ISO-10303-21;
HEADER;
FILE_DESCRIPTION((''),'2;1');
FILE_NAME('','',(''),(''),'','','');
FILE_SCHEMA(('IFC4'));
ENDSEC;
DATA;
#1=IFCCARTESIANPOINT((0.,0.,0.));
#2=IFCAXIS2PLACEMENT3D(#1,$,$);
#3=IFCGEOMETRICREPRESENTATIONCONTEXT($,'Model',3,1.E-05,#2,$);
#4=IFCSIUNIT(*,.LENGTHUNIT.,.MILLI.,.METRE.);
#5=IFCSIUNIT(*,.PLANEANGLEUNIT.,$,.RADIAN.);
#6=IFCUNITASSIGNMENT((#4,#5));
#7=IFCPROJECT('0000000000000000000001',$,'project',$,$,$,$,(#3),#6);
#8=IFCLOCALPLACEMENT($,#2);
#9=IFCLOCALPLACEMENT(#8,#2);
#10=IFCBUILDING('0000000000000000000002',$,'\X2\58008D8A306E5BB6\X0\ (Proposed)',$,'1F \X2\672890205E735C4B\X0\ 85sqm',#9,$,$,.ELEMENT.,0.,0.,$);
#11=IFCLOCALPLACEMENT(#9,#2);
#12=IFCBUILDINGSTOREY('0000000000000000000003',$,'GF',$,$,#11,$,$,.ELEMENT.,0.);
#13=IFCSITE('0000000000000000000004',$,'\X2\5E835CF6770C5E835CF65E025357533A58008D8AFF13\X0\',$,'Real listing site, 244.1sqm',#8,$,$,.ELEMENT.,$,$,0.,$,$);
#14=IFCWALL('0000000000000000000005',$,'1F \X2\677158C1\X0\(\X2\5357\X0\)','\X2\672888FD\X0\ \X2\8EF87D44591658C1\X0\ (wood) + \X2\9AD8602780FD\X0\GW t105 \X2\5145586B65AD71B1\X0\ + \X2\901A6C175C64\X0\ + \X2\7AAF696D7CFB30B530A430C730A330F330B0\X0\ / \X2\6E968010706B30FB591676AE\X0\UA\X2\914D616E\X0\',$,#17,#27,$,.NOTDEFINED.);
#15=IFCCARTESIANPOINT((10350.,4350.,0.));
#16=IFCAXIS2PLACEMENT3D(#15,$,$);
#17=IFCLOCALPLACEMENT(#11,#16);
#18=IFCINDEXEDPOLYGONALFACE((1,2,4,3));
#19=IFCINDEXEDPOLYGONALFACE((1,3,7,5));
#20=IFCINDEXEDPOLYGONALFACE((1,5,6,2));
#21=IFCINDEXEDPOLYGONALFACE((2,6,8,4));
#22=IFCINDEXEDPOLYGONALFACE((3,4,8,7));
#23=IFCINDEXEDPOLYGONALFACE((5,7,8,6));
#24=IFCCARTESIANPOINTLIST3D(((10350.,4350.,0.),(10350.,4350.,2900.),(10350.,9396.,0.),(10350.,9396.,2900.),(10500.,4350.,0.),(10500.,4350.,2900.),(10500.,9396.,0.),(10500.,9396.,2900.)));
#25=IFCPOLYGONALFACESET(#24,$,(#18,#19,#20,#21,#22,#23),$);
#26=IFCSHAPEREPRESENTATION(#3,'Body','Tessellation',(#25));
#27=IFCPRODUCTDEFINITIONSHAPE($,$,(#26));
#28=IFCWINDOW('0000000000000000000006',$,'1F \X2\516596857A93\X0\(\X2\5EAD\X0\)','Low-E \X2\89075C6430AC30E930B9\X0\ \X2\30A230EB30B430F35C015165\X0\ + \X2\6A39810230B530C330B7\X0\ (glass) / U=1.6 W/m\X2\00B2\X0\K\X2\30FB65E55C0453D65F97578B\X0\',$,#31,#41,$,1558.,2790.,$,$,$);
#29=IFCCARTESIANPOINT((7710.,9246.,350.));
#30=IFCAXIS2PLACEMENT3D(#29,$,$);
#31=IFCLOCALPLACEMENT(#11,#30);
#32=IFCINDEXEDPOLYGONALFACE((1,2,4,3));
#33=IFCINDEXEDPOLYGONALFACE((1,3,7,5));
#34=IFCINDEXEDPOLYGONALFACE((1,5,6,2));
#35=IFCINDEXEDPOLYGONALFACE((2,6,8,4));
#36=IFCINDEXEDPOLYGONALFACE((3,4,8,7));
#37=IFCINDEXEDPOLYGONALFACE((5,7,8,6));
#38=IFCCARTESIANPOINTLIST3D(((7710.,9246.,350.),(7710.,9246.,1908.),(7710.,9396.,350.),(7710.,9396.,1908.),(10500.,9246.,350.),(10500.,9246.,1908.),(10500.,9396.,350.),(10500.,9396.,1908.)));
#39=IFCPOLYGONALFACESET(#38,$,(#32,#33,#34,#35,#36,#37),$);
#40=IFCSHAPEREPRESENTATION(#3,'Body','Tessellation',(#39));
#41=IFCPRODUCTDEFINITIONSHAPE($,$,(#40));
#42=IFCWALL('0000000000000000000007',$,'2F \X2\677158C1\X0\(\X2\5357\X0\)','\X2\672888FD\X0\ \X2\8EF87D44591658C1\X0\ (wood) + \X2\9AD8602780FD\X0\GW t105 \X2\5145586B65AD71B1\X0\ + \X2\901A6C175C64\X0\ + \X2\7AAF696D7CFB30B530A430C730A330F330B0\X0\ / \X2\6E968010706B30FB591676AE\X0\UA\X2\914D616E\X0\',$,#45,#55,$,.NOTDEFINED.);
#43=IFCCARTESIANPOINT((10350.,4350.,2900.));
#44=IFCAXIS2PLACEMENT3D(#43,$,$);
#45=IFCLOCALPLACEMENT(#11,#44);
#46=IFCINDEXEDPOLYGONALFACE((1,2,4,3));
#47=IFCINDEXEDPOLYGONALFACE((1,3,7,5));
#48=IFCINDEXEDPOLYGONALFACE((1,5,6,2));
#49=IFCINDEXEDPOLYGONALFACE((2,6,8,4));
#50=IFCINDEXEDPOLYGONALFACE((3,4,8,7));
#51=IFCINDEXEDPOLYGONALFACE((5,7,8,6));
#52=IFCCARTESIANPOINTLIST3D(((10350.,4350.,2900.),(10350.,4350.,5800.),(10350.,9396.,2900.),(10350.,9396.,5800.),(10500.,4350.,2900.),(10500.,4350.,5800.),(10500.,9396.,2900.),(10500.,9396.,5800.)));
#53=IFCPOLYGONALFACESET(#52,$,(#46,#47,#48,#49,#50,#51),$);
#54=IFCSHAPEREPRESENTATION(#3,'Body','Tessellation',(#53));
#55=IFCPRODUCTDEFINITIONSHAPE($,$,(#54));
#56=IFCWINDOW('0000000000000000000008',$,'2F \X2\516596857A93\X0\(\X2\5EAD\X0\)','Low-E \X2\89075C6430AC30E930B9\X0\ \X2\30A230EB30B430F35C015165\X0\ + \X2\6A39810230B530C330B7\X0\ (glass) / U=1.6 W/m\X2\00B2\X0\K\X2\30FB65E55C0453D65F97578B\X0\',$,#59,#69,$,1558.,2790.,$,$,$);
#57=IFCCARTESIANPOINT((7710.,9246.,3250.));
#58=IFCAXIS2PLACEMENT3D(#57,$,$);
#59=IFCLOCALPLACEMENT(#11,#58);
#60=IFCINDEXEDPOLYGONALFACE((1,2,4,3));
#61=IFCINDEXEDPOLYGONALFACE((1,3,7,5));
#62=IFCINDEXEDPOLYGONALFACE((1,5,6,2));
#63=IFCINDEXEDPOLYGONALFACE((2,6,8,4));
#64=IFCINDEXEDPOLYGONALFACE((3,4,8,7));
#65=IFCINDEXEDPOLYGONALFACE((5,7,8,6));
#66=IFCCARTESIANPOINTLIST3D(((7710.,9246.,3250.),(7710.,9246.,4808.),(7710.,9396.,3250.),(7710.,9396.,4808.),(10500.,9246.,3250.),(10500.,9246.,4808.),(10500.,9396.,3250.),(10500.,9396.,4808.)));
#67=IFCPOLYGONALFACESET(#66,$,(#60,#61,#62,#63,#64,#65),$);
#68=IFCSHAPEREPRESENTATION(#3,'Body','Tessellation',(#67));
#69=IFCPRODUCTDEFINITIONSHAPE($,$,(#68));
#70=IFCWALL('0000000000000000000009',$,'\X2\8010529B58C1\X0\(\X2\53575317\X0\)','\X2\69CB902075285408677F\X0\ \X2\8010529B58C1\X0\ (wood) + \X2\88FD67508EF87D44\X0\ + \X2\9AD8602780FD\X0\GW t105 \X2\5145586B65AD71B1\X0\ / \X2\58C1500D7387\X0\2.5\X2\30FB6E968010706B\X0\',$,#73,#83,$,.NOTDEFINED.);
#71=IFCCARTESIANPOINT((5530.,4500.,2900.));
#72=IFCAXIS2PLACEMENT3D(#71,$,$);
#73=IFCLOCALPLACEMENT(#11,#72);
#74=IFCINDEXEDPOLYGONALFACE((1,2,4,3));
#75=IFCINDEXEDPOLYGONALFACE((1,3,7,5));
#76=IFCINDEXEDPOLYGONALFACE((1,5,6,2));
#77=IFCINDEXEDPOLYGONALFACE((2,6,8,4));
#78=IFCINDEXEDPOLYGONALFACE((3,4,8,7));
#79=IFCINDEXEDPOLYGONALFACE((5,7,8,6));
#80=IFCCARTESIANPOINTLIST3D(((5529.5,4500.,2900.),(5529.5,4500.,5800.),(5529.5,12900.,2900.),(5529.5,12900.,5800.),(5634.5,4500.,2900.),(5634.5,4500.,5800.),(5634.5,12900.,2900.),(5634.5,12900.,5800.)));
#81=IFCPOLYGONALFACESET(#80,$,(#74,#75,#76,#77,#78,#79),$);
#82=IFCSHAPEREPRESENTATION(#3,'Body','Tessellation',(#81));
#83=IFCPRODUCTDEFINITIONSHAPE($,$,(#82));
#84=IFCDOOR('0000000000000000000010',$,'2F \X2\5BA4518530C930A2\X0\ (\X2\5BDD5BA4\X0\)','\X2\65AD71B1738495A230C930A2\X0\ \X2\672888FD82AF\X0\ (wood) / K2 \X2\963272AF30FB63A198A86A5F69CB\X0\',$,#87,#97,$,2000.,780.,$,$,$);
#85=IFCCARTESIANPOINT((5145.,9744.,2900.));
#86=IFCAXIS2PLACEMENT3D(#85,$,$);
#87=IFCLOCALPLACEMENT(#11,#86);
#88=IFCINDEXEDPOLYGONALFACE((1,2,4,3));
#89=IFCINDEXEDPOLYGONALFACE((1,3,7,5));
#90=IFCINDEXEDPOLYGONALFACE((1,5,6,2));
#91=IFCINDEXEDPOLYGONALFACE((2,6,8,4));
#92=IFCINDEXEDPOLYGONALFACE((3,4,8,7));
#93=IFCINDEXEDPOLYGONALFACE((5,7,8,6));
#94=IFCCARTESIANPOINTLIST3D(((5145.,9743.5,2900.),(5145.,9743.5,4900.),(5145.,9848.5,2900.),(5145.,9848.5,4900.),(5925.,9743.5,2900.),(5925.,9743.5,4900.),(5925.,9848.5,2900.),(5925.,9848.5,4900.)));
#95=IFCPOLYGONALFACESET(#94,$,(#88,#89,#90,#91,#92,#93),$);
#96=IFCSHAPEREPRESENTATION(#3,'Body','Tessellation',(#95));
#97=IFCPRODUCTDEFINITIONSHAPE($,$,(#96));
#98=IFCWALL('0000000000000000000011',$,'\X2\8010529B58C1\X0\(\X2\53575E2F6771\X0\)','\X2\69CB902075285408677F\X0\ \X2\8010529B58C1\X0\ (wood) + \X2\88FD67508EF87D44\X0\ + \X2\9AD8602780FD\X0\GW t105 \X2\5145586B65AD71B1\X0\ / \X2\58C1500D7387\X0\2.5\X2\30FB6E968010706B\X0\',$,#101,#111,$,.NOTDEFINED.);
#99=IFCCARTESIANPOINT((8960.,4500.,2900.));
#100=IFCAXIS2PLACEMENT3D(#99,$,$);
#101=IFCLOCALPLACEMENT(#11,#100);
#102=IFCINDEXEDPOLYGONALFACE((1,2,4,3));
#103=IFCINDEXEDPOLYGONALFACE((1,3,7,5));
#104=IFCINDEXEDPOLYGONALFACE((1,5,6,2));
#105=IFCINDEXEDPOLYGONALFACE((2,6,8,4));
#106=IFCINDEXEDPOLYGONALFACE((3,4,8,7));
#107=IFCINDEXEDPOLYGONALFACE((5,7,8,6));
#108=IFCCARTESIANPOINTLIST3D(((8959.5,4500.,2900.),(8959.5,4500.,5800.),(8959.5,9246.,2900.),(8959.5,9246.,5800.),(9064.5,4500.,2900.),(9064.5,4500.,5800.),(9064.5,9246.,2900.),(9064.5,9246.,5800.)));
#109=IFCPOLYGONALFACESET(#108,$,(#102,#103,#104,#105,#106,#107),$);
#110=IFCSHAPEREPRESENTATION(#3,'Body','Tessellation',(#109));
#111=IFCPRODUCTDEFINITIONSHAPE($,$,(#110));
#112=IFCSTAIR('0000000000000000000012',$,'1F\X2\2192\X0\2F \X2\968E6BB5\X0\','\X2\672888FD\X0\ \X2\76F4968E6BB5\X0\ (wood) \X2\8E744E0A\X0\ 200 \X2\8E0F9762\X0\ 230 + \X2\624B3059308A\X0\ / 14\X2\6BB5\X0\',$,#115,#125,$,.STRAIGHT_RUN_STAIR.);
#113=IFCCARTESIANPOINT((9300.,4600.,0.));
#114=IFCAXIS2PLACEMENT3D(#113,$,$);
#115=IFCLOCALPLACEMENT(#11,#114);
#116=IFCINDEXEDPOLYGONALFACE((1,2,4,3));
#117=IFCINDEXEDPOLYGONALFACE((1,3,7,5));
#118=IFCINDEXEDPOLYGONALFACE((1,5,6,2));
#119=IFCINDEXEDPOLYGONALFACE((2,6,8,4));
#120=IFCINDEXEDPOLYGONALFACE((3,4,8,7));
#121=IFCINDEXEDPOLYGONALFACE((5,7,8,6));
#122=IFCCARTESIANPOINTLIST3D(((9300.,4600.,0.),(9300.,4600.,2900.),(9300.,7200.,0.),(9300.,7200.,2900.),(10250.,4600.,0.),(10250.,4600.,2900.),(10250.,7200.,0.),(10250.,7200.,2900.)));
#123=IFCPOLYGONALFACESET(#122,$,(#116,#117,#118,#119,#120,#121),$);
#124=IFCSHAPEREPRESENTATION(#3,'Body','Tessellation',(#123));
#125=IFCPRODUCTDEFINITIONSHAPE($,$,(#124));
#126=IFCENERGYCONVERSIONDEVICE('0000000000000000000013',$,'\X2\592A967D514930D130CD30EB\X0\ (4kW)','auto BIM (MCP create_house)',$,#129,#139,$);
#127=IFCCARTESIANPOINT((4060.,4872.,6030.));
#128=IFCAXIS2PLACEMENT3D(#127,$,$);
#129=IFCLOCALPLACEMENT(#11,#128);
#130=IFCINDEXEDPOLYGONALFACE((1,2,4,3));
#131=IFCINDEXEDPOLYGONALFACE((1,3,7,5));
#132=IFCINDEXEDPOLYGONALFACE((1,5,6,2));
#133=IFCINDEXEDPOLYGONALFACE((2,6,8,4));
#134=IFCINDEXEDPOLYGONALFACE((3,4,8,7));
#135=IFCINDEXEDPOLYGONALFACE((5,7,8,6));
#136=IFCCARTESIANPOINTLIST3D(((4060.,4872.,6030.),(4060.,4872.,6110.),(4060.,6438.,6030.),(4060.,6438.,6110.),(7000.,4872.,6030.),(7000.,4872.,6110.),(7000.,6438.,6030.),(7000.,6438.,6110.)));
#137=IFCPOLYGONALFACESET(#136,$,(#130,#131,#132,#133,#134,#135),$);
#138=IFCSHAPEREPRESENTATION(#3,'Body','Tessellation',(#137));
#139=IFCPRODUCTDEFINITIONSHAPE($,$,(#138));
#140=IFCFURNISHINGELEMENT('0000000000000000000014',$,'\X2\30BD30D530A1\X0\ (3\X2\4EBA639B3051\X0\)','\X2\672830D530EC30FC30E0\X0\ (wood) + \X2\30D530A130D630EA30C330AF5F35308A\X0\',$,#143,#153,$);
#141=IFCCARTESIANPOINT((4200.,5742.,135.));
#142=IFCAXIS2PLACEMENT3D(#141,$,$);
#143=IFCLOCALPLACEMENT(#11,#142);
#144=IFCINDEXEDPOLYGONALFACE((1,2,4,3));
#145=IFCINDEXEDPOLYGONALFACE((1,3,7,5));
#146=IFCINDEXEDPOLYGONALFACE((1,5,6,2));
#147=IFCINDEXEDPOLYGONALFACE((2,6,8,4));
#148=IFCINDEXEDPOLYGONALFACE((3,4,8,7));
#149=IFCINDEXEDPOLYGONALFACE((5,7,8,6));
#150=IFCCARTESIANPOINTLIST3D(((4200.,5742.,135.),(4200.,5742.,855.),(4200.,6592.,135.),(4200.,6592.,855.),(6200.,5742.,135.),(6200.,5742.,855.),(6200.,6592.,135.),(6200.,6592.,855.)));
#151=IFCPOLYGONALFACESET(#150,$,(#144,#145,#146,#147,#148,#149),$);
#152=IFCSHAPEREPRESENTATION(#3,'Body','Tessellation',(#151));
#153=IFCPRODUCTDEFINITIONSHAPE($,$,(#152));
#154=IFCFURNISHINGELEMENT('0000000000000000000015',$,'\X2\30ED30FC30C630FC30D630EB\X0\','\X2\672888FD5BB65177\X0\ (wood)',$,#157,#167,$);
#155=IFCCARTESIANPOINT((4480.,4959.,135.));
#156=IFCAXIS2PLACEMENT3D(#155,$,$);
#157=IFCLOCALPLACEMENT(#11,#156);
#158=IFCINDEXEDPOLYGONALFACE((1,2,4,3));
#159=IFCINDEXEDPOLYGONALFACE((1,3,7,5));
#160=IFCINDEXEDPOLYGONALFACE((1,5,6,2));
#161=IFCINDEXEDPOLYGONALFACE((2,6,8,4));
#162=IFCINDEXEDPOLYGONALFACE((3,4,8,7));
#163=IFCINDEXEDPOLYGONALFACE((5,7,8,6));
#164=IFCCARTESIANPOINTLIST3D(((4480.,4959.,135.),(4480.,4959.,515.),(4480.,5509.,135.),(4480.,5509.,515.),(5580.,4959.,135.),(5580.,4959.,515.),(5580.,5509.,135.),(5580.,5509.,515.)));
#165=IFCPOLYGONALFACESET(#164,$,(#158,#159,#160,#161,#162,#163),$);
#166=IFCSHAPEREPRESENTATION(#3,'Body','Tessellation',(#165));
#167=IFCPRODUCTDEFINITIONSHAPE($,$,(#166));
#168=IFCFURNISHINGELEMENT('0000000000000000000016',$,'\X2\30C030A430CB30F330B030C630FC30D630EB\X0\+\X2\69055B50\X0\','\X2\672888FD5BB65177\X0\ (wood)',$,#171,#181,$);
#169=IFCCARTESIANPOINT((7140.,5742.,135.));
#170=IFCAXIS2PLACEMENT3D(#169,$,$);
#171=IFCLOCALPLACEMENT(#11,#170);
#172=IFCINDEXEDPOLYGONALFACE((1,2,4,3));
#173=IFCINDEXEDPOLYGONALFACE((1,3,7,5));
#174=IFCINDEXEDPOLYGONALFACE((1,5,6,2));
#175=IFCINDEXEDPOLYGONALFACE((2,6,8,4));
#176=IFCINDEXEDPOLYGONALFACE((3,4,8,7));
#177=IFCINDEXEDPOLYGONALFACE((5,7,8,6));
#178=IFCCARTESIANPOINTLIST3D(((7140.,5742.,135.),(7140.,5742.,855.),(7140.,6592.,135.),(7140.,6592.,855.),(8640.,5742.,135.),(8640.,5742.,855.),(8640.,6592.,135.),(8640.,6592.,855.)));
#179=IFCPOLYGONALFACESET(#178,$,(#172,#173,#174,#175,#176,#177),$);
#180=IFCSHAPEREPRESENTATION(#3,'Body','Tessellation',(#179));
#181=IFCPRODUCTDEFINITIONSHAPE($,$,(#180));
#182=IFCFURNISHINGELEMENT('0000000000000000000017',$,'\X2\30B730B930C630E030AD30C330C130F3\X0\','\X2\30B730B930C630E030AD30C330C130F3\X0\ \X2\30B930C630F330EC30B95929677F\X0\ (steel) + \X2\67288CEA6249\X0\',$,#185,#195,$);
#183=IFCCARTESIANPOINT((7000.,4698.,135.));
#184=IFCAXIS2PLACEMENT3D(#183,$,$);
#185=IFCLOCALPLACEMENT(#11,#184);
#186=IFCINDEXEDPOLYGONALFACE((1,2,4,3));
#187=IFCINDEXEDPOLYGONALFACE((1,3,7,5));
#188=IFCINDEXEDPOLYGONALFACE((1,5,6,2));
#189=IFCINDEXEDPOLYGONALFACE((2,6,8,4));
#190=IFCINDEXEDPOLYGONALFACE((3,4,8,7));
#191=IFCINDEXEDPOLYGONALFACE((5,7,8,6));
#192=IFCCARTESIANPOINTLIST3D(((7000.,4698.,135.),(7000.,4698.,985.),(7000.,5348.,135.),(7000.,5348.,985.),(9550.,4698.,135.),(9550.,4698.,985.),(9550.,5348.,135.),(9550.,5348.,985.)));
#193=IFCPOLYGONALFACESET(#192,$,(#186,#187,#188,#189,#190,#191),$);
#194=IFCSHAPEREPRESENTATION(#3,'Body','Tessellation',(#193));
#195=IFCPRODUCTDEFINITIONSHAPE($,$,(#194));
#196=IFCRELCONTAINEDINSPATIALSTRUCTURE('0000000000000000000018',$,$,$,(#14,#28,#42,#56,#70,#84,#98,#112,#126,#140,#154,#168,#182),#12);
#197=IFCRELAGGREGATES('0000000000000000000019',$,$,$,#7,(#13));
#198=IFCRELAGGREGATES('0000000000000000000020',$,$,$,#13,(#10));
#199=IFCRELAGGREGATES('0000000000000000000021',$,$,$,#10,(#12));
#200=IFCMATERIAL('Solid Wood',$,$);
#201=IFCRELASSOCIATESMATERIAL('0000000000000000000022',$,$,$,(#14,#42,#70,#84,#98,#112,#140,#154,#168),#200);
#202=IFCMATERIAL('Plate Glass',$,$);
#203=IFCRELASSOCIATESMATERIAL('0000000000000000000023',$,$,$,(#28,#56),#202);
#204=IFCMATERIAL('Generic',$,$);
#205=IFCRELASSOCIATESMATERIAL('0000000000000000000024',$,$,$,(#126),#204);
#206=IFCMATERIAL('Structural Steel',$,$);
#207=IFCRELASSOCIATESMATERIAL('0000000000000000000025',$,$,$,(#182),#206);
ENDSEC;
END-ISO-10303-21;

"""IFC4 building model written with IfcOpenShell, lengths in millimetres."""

from ifc_helpers import new_model, si_unit, frame, frame_2d, origin, place, context, project, spatial, rectangle, extrude, material, element, fill, save


model = new_model("IFC4")

# Units and contexts
model_context = context("Model", 3, precision=1e-05, world=origin())
ifc_project = project(units=[si_unit("LENGTHUNIT", "METRE", prefix="MILLI"), si_unit("PLANEANGLEUNIT", "RADIAN")], contexts=[model_context])

# Site, building, storey
site_placement = place(None, origin())
site = spatial("IfcSite", under=ifc_project, at=site_placement, Name="広島県広島市南区堀越３", ObjectType="Real listing site, 244.1sqm", CompositionType="ELEMENT", RefElevation=0.0)
building_placement = place(site_placement, origin())
building = spatial("IfcBuilding", under=site, at=building_placement, Name="堀越の家 (Proposed)", ObjectType="1F 木造平屋 85sqm", CompositionType="ELEMENT", ElevationOfRefHeight=0.0, ElevationOfTerrain=0.0)
storey_placement = place(building_placement, origin())
storey = spatial("IfcBuildingStorey", under=building, at=storey_placement, Name="GF", CompositionType="ELEMENT", Elevation=0.0)

# Wall, opening, window
ifc_material_1 = material(Name="Solid Wood")
wall_1_placement = place(storey_placement, frame((10350.0, 4350.0, 0.0)))
wall_1 = element("IfcWall", 1, at=wall_1_placement, inside=storey, material=ifc_material_1, Name="1F 東壁(南)", Description="木製 軸組外壁 (wood) + 高性能GW t105 充填断熱 + 通気層 + 窯業系サイディング / 準耐火・外皮UA配慮", PredefinedType="NOTDEFINED", context=model_context, shape_type="SweptSolid", body=[
    extrude(rectangle(XDim=150.0, YDim=5046.0, at=frame_2d((75.0, 2523.0))), frame((10350.0, 4350.0, 0.0)), (0.0, 0.0, 1.0), 2900.0),
])
opening_1_placement = place(storey_placement, frame((7710.0, 9246.0, 350.0)))
opening_1 = element("IfcOpeningElement", 2, at=opening_1_placement, cuts=wall_1, PredefinedType="NOTDEFINED", context=model_context, shape_type="SweptSolid", body=[
    extrude(rectangle(XDim=2790.0, YDim=150.0, at=frame_2d((1395.0, 75.0))), frame((7710.0, 9246.0, 350.0)), (0.0, 0.0, 1.0), 1558.0),
])
ifc_material_2 = material(Name="Plate Glass")
window_1_placement = place(storey_placement, frame((7710.0, 9246.0, 350.0)))
window_1 = element("IfcWindow", 3, at=window_1_placement, inside=storey, material=ifc_material_2, Name="1F 入隅窓(庭)", Description="Low-E 複層ガラス アルゴン封入 + 樹脂サッシ (glass) / U=1.6 W/m²K・日射取得型", OverallHeight=1558.0, OverallWidth=2790.0, context=model_context, shape_type="SweptSolid", body=[
    extrude(rectangle(XDim=2790.0, YDim=150.0, at=frame_2d((1395.0, 75.0))), frame((7710.0, 9246.0, 350.0)), (0.0, 0.0, 1.0), 1558.0),
])
fill(opening_1, window_1)

# Wall, opening, window
wall_2_placement = place(storey_placement, frame((10350.0, 4350.0, 2900.0)))
wall_2 = element("IfcWall", 4, at=wall_2_placement, inside=storey, material=ifc_material_1, Name="2F 東壁(南)", Description="木製 軸組外壁 (wood) + 高性能GW t105 充填断熱 + 通気層 + 窯業系サイディング / 準耐火・外皮UA配慮", PredefinedType="NOTDEFINED", context=model_context, shape_type="SweptSolid", body=[
    extrude(rectangle(XDim=150.0, YDim=5046.0, at=frame_2d((75.0, 2523.0))), frame((10350.0, 4350.0, 2900.0)), (0.0, 0.0, 1.0), 2900.0),
])
opening_2_placement = place(storey_placement, frame((7710.0, 9246.0, 3250.0)))
opening_2 = element("IfcOpeningElement", 5, at=opening_2_placement, cuts=wall_2, PredefinedType="NOTDEFINED", context=model_context, shape_type="SweptSolid", body=[
    extrude(rectangle(XDim=2790.0, YDim=150.0, at=frame_2d((1395.0, 75.0))), frame((7710.0, 9246.0, 3250.0)), (0.0, 0.0, 1.0), 1558.0),
])
window_2_placement = place(storey_placement, frame((7710.0, 9246.0, 3250.0)))
window_2 = element("IfcWindow", 6, at=window_2_placement, inside=storey, material=ifc_material_2, Name="2F 入隅窓(庭)", Description="Low-E 複層ガラス アルゴン封入 + 樹脂サッシ (glass) / U=1.6 W/m²K・日射取得型", OverallHeight=1558.0, OverallWidth=2790.0, context=model_context, shape_type="SweptSolid", body=[
    extrude(rectangle(XDim=2790.0, YDim=150.0, at=frame_2d((1395.0, 75.0))), frame((7710.0, 9246.0, 3250.0)), (0.0, 0.0, 1.0), 1558.0),
])
fill(opening_2, window_2)

# Wall, opening, door
wall_3_placement = place(storey_placement, frame((5530.0, 4500.0, 2900.0)))
wall_3 = element("IfcWall", 7, at=wall_3_placement, inside=storey, material=ifc_material_1, Name="耐力壁(南北)", Description="構造用合板 耐力壁 (wood) + 製材軸組 + 高性能GW t105 充填断熱 / 壁倍率2.5・準耐火", PredefinedType="NOTDEFINED", context=model_context, shape_type="SweptSolid", body=[
    extrude(rectangle(XDim=105.0, YDim=8400.0, at=frame_2d((52.0, 4200.0))), frame((5530.0, 4500.0, 2900.0)), (0.0, 0.0, 1.0), 2900.0),
])
opening_3_placement = place(storey_placement, frame((5145.0, 9744.0, 2900.0)))
opening_3 = element("IfcOpeningElement", 8, at=opening_3_placement, cuts=wall_3, PredefinedType="NOTDEFINED", context=model_context, shape_type="SweptSolid", body=[
    extrude(rectangle(XDim=780.0, YDim=105.0, at=frame_2d((390.0, 52.0))), frame((5145.0, 9744.0, 2900.0)), (0.0, 0.0, 1.0), 2000.0),
])
door_1_placement = place(storey_placement, frame((5145.0, 9744.0, 2900.0)))
door_1 = element("IfcDoor", 9, at=door_1_placement, inside=storey, material=ifc_material_1, Name="2F 室内ドア (寝室)", Description="断熱玄関ドア 木製芯 (wood) / K2 防犯・採風機構", OverallHeight=2000.0, OverallWidth=780.0, context=model_context, shape_type="SweptSolid", body=[
    extrude(rectangle(XDim=780.0, YDim=105.0, at=frame_2d((390.0, 52.0))), frame((5145.0, 9744.0, 2900.0)), (0.0, 0.0, 1.0), 2000.0),
])
fill(opening_3, door_1)

# Wall
wall_4_placement = place(storey_placement, frame((8960.0, 4500.0, 2900.0)))
element("IfcWall", 10, at=wall_4_placement, inside=storey, material=ifc_material_1, Name="耐力壁(南帯東)", Description="構造用合板 耐力壁 (wood) + 製材軸組 + 高性能GW t105 充填断熱 / 壁倍率2.5・準耐火", PredefinedType="NOTDEFINED", context=model_context, shape_type="SweptSolid", body=[
    extrude(rectangle(XDim=105.0, YDim=4746.0, at=frame_2d((52.0, 2373.0))), frame((8960.0, 4500.0, 2900.0)), (0.0, 0.0, 1.0), 2900.0),
])

# Stair
stair_placement = place(storey_placement, frame((9300.0, 4600.0, 0.0)))
element("IfcStair", 11, at=stair_placement, inside=storey, material=ifc_material_1, Name="1F→2F 階段", Description="木製 直階段 (wood) 蹴上 200 踏面 230 + 手すり / 14段", PredefinedType="STRAIGHT_RUN_STAIR", context=model_context, shape_type="SweptSolid", body=[
    extrude(rectangle(XDim=950.0, YDim=2600.0, at=frame_2d((475.0, 1300.0))), frame((9300.0, 4600.0, 0.0)), (0.0, 0.0, 1.0), 2900.0),
])

# Energy conversion device
ifc_material_3 = material(Name="Generic")
energy_conversion_device_placement = place(storey_placement, frame((4060.0, 4872.0, 6030.0)))
element("IfcEnergyConversionDevice", 12, at=energy_conversion_device_placement, inside=storey, material=ifc_material_3, Name="太陽光パネル (4kW)", Description="auto BIM (MCP create_house)", context=model_context, shape_type="SweptSolid", body=[
    extrude(rectangle(XDim=2940.0, YDim=1566.0, at=frame_2d((1470.0, 783.0))), frame((4060.0, 4872.0, 6030.0)), (0.0, 0.0, 1.0), 80.0),
])

# Furnishing elements
furnishing_1_placement = place(storey_placement, frame((4200.0, 5742.0, 135.0)))
element("IfcFurnishingElement", 13, at=furnishing_1_placement, inside=storey, material=ifc_material_1, Name="ソファ (3人掛け)", Description="木フレーム (wood) + ファブリック張り", context=model_context, shape_type="SweptSolid", body=[
    extrude(rectangle(XDim=2000.0, YDim=850.0, at=frame_2d((1000.0, 425.0))), frame((4200.0, 5742.0, 135.0)), (0.0, 0.0, 1.0), 720.0),
])
furnishing_2_placement = place(storey_placement, frame((4480.0, 4959.0, 135.0)))
element("IfcFurnishingElement", 14, at=furnishing_2_placement, inside=storey, material=ifc_material_1, Name="ローテーブル", Description="木製家具 (wood)", context=model_context, shape_type="SweptSolid", body=[
    extrude(rectangle(XDim=1100.0, YDim=550.0, at=frame_2d((550.0, 275.0))), frame((4480.0, 4959.0, 135.0)), (0.0, 0.0, 1.0), 380.0),
])
furnishing_3_placement = place(storey_placement, frame((7140.0, 5742.0, 135.0)))
element("IfcFurnishingElement", 15, at=furnishing_3_placement, inside=storey, material=ifc_material_1, Name="ダイニングテーブル+椅子", Description="木製家具 (wood)", context=model_context, shape_type="SweptSolid", body=[
    extrude(rectangle(XDim=1500.0, YDim=850.0, at=frame_2d((750.0, 425.0))), frame((7140.0, 5742.0, 135.0)), (0.0, 0.0, 1.0), 720.0),
])
ifc_material_4 = material(Name="Structural Steel")
furnishing_4_placement = place(storey_placement, frame((7000.0, 4698.0, 135.0)))
element("IfcFurnishingElement", 16, at=furnishing_4_placement, inside=storey, material=ifc_material_4, Name="システムキッチン", Description="システムキッチン ステンレス天板 (steel) + 木質扉", context=model_context, shape_type="SweptSolid", body=[
    extrude(rectangle(XDim=2550.0, YDim=650.0, at=frame_2d((1275.0, 325.0))), frame((7000.0, 4698.0, 135.0)), (0.0, 0.0, 1.0), 850.0),
])

save(model, "model.ifc")
